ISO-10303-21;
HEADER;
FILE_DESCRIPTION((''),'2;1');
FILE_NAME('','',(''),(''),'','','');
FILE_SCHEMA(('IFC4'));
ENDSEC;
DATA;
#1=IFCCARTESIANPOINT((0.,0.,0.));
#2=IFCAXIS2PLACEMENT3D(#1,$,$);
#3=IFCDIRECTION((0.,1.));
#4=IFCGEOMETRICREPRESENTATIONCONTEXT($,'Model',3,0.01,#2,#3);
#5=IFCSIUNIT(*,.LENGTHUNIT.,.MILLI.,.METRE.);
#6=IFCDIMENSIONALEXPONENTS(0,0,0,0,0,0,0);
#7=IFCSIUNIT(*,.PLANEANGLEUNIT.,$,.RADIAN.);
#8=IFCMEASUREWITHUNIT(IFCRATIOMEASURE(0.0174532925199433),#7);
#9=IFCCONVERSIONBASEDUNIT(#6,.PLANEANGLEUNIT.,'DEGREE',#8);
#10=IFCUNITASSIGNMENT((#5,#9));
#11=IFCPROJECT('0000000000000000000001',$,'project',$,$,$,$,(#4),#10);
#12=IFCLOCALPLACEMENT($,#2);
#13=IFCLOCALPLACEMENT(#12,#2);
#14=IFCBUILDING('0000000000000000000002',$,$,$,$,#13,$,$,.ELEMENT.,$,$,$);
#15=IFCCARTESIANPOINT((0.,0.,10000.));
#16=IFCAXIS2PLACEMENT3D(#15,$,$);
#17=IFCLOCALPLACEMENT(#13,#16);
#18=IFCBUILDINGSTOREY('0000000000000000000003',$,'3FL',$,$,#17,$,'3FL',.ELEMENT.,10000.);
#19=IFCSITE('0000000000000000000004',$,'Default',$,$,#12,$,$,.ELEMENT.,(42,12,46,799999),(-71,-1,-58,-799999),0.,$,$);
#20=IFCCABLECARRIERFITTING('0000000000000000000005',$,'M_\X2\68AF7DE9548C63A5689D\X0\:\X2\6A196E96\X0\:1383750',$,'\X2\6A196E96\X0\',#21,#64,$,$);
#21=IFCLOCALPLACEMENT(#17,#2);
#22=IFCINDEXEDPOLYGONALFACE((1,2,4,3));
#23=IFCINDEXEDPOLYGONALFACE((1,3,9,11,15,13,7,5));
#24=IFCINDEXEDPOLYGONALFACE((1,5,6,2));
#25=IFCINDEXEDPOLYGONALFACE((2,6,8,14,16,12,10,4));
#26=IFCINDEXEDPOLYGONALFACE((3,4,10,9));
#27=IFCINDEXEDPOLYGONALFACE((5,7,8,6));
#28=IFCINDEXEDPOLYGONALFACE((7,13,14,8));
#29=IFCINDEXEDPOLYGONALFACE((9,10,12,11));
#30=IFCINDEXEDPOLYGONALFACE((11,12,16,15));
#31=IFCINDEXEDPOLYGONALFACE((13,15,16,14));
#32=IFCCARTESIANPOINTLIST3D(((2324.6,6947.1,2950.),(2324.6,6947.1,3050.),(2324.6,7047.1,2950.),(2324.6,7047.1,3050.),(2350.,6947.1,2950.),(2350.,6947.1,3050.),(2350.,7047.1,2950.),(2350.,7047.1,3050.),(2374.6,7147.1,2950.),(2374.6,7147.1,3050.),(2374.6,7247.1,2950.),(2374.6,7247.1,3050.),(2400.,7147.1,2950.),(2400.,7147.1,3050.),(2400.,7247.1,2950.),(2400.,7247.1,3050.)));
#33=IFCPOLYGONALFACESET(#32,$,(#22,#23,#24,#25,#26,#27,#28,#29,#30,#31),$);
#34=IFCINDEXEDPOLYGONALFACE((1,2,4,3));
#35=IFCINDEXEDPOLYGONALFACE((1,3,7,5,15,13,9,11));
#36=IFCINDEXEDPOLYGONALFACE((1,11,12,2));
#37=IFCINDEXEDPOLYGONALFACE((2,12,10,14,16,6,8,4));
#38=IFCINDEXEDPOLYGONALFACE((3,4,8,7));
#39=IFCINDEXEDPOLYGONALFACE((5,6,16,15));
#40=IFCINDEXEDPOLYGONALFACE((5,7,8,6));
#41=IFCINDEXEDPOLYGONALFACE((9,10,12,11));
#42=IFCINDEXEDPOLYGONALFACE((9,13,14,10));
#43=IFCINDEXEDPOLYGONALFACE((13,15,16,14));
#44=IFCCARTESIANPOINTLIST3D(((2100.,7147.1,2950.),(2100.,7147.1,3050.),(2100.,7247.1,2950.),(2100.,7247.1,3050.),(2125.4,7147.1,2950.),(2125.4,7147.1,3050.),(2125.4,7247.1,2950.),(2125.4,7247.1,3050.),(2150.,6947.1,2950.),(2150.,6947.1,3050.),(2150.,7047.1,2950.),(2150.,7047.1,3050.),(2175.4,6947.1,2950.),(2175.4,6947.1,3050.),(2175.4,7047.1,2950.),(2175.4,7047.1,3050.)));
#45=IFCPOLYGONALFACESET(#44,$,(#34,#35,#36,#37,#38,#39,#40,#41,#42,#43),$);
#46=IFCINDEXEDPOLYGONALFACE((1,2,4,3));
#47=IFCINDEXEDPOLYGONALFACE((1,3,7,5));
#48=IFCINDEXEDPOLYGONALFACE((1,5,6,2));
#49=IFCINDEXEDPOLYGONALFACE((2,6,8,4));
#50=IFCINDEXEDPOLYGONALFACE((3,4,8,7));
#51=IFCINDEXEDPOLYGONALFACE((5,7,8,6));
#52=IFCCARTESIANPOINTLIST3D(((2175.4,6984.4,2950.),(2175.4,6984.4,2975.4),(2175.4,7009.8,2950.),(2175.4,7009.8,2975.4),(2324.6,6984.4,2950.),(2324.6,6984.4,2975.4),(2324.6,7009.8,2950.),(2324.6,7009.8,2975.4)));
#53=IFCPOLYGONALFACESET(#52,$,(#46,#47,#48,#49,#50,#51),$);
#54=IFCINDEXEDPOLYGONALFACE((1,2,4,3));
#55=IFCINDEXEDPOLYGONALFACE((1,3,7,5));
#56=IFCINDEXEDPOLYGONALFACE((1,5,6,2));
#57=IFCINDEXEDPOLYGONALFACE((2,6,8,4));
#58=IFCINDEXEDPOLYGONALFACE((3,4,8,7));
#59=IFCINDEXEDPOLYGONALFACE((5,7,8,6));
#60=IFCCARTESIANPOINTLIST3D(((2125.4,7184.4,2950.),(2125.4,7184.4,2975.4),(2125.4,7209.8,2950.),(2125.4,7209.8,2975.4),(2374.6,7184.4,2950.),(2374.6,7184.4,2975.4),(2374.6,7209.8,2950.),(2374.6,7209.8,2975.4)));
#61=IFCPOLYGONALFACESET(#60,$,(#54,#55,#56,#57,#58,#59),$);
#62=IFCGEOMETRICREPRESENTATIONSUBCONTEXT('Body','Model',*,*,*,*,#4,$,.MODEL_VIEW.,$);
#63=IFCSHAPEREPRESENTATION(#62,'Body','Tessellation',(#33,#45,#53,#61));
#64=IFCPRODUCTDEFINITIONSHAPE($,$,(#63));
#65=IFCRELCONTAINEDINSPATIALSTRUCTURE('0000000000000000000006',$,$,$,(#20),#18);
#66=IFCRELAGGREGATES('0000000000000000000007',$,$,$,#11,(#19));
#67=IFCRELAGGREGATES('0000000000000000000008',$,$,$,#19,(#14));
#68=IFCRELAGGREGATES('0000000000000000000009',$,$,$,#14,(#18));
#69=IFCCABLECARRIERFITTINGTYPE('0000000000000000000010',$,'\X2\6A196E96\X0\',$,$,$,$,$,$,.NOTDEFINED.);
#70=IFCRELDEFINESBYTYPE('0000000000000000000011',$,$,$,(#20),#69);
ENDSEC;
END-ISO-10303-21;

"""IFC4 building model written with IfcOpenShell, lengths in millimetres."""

from ifc_helpers import new_model, entity, si_unit, converted_unit, direction, frame, frame_2d, origin, origin_2d_with_axis, place, context, subcontext, project, spatial, polyline, rectangle, outline, extrude, source, transform, mapped, type_object, type_shapes, element, save


model = new_model("IFC4")

# Units and contexts
model_context = context("Model", 3, precision=0.01, world=origin(), true_north=direction((0.0, 1.0)))
body_context = subcontext(model_context, "Body", "Model", "MODEL_VIEW")
ifc_project = project(units=[si_unit("LENGTHUNIT", "METRE", prefix="MILLI"), converted_unit("PLANEANGLEUNIT", "DEGREE", entity("IfcRatioMeasure", 0.0174532925199433), si_unit("PLANEANGLEUNIT", "RADIAN"), dimensions=[0, 0, 0, 0, 0, 0, 0])], contexts=[model_context])

# Site, building, storey
site_placement = place(None, origin())
site = spatial("IfcSite", under=ifc_project, at=site_placement, Name="Default", CompositionType="ELEMENT", RefLatitude=(42, 12, 46, 799999), RefLongitude=(-71, -1, -58, -799999), RefElevation=0.0)
building_placement = place(site_placement, origin())
building = spatial("IfcBuilding", under=site, at=building_placement, CompositionType="ELEMENT")
storey_placement = place(building_placement, frame((0.0, 0.0, 10000.0)))
storey = spatial("IfcBuildingStorey", under=building, at=storey_placement, Name="3FL", LongName="3FL", CompositionType="ELEMENT", Elevation=10000.0)

# Cable carrier fitting
cable_carrier_fitting_type_1 = type_object("IfcCableCarrierFittingType", Name="標準", PredefinedType="NOTDEFINED")
shared_shape_1 = source(origin(), body_context, "Body", "SweptSolid", [
    extrude(outline(polyline([(-150.0, -12.3), (-150.0, -37.7), (-50.0, -37.7), (50.0, 12.3), (150.0, 12.3), (150.0, 37.7), (50.0, 37.7), (-50.0, -12.3), (-150.0, -12.3)])), frame((150.0, 112.3, -50.0), z_axis=(0.0, 0.0, -1.0), x_axis=(1.0, 0.0, 0.0)), (0.0, 0.0, -1.0), 100.0),
    extrude(outline(polyline([(-150.0, -37.7), (-50.0, -37.7), (50.0, 12.3), (150.0, 12.3), (150.0, 37.7), (50.0, 37.7), (-50.0, -12.3), (-150.0, -12.3), (-150.0, -37.7)])), frame((150.0, -112.3, -50.0)), (0.0, 0.0, 1.0), 100.0),
    extrude(rectangle(XDim=149.2, YDim=25.4, at=frame_2d((0.0, 0.0), x_axis=(1.0, 0.0))), frame((250.0, 0.0, -50.0), z_axis=(0.0, 0.0, 1.0), x_axis=(0.0, -1.0, 0.0)), (0.0, 0.0, 1.0), 25.4),
    extrude(rectangle(XDim=249.2, YDim=25.4, at=origin_2d_with_axis()), frame((50.0, 0.0, -50.0), z_axis=(0.0, 0.0, 1.0), x_axis=(0.0, -1.0, 0.0)), (0.0, 0.0, 1.0), 25.4),
])
type_shapes(cable_carrier_fitting_type_1, [shared_shape_1])
for number, where, z_axis, x_axis, name in (
    (1, (2250.0, 7247.1, 3000.0), (0.0, 0.0, 1.0), (0.0, -1.0, 0.0), "M_梯緩和接條:標準:1383750"),
):
    element("IfcCableCarrierFitting", number, at=place(storey_placement, frame(where, z_axis=z_axis, x_axis=x_axis)), inside=storey, type_object=cable_carrier_fitting_type_1, Name=name, ObjectType="標準", context=body_context, shape_type="MappedRepresentation", body=[
        mapped(shared_shape_1, transform((0.0, 0.0, 0.0), scale=1.0)),
    ])

save(model, "model.ifc")
